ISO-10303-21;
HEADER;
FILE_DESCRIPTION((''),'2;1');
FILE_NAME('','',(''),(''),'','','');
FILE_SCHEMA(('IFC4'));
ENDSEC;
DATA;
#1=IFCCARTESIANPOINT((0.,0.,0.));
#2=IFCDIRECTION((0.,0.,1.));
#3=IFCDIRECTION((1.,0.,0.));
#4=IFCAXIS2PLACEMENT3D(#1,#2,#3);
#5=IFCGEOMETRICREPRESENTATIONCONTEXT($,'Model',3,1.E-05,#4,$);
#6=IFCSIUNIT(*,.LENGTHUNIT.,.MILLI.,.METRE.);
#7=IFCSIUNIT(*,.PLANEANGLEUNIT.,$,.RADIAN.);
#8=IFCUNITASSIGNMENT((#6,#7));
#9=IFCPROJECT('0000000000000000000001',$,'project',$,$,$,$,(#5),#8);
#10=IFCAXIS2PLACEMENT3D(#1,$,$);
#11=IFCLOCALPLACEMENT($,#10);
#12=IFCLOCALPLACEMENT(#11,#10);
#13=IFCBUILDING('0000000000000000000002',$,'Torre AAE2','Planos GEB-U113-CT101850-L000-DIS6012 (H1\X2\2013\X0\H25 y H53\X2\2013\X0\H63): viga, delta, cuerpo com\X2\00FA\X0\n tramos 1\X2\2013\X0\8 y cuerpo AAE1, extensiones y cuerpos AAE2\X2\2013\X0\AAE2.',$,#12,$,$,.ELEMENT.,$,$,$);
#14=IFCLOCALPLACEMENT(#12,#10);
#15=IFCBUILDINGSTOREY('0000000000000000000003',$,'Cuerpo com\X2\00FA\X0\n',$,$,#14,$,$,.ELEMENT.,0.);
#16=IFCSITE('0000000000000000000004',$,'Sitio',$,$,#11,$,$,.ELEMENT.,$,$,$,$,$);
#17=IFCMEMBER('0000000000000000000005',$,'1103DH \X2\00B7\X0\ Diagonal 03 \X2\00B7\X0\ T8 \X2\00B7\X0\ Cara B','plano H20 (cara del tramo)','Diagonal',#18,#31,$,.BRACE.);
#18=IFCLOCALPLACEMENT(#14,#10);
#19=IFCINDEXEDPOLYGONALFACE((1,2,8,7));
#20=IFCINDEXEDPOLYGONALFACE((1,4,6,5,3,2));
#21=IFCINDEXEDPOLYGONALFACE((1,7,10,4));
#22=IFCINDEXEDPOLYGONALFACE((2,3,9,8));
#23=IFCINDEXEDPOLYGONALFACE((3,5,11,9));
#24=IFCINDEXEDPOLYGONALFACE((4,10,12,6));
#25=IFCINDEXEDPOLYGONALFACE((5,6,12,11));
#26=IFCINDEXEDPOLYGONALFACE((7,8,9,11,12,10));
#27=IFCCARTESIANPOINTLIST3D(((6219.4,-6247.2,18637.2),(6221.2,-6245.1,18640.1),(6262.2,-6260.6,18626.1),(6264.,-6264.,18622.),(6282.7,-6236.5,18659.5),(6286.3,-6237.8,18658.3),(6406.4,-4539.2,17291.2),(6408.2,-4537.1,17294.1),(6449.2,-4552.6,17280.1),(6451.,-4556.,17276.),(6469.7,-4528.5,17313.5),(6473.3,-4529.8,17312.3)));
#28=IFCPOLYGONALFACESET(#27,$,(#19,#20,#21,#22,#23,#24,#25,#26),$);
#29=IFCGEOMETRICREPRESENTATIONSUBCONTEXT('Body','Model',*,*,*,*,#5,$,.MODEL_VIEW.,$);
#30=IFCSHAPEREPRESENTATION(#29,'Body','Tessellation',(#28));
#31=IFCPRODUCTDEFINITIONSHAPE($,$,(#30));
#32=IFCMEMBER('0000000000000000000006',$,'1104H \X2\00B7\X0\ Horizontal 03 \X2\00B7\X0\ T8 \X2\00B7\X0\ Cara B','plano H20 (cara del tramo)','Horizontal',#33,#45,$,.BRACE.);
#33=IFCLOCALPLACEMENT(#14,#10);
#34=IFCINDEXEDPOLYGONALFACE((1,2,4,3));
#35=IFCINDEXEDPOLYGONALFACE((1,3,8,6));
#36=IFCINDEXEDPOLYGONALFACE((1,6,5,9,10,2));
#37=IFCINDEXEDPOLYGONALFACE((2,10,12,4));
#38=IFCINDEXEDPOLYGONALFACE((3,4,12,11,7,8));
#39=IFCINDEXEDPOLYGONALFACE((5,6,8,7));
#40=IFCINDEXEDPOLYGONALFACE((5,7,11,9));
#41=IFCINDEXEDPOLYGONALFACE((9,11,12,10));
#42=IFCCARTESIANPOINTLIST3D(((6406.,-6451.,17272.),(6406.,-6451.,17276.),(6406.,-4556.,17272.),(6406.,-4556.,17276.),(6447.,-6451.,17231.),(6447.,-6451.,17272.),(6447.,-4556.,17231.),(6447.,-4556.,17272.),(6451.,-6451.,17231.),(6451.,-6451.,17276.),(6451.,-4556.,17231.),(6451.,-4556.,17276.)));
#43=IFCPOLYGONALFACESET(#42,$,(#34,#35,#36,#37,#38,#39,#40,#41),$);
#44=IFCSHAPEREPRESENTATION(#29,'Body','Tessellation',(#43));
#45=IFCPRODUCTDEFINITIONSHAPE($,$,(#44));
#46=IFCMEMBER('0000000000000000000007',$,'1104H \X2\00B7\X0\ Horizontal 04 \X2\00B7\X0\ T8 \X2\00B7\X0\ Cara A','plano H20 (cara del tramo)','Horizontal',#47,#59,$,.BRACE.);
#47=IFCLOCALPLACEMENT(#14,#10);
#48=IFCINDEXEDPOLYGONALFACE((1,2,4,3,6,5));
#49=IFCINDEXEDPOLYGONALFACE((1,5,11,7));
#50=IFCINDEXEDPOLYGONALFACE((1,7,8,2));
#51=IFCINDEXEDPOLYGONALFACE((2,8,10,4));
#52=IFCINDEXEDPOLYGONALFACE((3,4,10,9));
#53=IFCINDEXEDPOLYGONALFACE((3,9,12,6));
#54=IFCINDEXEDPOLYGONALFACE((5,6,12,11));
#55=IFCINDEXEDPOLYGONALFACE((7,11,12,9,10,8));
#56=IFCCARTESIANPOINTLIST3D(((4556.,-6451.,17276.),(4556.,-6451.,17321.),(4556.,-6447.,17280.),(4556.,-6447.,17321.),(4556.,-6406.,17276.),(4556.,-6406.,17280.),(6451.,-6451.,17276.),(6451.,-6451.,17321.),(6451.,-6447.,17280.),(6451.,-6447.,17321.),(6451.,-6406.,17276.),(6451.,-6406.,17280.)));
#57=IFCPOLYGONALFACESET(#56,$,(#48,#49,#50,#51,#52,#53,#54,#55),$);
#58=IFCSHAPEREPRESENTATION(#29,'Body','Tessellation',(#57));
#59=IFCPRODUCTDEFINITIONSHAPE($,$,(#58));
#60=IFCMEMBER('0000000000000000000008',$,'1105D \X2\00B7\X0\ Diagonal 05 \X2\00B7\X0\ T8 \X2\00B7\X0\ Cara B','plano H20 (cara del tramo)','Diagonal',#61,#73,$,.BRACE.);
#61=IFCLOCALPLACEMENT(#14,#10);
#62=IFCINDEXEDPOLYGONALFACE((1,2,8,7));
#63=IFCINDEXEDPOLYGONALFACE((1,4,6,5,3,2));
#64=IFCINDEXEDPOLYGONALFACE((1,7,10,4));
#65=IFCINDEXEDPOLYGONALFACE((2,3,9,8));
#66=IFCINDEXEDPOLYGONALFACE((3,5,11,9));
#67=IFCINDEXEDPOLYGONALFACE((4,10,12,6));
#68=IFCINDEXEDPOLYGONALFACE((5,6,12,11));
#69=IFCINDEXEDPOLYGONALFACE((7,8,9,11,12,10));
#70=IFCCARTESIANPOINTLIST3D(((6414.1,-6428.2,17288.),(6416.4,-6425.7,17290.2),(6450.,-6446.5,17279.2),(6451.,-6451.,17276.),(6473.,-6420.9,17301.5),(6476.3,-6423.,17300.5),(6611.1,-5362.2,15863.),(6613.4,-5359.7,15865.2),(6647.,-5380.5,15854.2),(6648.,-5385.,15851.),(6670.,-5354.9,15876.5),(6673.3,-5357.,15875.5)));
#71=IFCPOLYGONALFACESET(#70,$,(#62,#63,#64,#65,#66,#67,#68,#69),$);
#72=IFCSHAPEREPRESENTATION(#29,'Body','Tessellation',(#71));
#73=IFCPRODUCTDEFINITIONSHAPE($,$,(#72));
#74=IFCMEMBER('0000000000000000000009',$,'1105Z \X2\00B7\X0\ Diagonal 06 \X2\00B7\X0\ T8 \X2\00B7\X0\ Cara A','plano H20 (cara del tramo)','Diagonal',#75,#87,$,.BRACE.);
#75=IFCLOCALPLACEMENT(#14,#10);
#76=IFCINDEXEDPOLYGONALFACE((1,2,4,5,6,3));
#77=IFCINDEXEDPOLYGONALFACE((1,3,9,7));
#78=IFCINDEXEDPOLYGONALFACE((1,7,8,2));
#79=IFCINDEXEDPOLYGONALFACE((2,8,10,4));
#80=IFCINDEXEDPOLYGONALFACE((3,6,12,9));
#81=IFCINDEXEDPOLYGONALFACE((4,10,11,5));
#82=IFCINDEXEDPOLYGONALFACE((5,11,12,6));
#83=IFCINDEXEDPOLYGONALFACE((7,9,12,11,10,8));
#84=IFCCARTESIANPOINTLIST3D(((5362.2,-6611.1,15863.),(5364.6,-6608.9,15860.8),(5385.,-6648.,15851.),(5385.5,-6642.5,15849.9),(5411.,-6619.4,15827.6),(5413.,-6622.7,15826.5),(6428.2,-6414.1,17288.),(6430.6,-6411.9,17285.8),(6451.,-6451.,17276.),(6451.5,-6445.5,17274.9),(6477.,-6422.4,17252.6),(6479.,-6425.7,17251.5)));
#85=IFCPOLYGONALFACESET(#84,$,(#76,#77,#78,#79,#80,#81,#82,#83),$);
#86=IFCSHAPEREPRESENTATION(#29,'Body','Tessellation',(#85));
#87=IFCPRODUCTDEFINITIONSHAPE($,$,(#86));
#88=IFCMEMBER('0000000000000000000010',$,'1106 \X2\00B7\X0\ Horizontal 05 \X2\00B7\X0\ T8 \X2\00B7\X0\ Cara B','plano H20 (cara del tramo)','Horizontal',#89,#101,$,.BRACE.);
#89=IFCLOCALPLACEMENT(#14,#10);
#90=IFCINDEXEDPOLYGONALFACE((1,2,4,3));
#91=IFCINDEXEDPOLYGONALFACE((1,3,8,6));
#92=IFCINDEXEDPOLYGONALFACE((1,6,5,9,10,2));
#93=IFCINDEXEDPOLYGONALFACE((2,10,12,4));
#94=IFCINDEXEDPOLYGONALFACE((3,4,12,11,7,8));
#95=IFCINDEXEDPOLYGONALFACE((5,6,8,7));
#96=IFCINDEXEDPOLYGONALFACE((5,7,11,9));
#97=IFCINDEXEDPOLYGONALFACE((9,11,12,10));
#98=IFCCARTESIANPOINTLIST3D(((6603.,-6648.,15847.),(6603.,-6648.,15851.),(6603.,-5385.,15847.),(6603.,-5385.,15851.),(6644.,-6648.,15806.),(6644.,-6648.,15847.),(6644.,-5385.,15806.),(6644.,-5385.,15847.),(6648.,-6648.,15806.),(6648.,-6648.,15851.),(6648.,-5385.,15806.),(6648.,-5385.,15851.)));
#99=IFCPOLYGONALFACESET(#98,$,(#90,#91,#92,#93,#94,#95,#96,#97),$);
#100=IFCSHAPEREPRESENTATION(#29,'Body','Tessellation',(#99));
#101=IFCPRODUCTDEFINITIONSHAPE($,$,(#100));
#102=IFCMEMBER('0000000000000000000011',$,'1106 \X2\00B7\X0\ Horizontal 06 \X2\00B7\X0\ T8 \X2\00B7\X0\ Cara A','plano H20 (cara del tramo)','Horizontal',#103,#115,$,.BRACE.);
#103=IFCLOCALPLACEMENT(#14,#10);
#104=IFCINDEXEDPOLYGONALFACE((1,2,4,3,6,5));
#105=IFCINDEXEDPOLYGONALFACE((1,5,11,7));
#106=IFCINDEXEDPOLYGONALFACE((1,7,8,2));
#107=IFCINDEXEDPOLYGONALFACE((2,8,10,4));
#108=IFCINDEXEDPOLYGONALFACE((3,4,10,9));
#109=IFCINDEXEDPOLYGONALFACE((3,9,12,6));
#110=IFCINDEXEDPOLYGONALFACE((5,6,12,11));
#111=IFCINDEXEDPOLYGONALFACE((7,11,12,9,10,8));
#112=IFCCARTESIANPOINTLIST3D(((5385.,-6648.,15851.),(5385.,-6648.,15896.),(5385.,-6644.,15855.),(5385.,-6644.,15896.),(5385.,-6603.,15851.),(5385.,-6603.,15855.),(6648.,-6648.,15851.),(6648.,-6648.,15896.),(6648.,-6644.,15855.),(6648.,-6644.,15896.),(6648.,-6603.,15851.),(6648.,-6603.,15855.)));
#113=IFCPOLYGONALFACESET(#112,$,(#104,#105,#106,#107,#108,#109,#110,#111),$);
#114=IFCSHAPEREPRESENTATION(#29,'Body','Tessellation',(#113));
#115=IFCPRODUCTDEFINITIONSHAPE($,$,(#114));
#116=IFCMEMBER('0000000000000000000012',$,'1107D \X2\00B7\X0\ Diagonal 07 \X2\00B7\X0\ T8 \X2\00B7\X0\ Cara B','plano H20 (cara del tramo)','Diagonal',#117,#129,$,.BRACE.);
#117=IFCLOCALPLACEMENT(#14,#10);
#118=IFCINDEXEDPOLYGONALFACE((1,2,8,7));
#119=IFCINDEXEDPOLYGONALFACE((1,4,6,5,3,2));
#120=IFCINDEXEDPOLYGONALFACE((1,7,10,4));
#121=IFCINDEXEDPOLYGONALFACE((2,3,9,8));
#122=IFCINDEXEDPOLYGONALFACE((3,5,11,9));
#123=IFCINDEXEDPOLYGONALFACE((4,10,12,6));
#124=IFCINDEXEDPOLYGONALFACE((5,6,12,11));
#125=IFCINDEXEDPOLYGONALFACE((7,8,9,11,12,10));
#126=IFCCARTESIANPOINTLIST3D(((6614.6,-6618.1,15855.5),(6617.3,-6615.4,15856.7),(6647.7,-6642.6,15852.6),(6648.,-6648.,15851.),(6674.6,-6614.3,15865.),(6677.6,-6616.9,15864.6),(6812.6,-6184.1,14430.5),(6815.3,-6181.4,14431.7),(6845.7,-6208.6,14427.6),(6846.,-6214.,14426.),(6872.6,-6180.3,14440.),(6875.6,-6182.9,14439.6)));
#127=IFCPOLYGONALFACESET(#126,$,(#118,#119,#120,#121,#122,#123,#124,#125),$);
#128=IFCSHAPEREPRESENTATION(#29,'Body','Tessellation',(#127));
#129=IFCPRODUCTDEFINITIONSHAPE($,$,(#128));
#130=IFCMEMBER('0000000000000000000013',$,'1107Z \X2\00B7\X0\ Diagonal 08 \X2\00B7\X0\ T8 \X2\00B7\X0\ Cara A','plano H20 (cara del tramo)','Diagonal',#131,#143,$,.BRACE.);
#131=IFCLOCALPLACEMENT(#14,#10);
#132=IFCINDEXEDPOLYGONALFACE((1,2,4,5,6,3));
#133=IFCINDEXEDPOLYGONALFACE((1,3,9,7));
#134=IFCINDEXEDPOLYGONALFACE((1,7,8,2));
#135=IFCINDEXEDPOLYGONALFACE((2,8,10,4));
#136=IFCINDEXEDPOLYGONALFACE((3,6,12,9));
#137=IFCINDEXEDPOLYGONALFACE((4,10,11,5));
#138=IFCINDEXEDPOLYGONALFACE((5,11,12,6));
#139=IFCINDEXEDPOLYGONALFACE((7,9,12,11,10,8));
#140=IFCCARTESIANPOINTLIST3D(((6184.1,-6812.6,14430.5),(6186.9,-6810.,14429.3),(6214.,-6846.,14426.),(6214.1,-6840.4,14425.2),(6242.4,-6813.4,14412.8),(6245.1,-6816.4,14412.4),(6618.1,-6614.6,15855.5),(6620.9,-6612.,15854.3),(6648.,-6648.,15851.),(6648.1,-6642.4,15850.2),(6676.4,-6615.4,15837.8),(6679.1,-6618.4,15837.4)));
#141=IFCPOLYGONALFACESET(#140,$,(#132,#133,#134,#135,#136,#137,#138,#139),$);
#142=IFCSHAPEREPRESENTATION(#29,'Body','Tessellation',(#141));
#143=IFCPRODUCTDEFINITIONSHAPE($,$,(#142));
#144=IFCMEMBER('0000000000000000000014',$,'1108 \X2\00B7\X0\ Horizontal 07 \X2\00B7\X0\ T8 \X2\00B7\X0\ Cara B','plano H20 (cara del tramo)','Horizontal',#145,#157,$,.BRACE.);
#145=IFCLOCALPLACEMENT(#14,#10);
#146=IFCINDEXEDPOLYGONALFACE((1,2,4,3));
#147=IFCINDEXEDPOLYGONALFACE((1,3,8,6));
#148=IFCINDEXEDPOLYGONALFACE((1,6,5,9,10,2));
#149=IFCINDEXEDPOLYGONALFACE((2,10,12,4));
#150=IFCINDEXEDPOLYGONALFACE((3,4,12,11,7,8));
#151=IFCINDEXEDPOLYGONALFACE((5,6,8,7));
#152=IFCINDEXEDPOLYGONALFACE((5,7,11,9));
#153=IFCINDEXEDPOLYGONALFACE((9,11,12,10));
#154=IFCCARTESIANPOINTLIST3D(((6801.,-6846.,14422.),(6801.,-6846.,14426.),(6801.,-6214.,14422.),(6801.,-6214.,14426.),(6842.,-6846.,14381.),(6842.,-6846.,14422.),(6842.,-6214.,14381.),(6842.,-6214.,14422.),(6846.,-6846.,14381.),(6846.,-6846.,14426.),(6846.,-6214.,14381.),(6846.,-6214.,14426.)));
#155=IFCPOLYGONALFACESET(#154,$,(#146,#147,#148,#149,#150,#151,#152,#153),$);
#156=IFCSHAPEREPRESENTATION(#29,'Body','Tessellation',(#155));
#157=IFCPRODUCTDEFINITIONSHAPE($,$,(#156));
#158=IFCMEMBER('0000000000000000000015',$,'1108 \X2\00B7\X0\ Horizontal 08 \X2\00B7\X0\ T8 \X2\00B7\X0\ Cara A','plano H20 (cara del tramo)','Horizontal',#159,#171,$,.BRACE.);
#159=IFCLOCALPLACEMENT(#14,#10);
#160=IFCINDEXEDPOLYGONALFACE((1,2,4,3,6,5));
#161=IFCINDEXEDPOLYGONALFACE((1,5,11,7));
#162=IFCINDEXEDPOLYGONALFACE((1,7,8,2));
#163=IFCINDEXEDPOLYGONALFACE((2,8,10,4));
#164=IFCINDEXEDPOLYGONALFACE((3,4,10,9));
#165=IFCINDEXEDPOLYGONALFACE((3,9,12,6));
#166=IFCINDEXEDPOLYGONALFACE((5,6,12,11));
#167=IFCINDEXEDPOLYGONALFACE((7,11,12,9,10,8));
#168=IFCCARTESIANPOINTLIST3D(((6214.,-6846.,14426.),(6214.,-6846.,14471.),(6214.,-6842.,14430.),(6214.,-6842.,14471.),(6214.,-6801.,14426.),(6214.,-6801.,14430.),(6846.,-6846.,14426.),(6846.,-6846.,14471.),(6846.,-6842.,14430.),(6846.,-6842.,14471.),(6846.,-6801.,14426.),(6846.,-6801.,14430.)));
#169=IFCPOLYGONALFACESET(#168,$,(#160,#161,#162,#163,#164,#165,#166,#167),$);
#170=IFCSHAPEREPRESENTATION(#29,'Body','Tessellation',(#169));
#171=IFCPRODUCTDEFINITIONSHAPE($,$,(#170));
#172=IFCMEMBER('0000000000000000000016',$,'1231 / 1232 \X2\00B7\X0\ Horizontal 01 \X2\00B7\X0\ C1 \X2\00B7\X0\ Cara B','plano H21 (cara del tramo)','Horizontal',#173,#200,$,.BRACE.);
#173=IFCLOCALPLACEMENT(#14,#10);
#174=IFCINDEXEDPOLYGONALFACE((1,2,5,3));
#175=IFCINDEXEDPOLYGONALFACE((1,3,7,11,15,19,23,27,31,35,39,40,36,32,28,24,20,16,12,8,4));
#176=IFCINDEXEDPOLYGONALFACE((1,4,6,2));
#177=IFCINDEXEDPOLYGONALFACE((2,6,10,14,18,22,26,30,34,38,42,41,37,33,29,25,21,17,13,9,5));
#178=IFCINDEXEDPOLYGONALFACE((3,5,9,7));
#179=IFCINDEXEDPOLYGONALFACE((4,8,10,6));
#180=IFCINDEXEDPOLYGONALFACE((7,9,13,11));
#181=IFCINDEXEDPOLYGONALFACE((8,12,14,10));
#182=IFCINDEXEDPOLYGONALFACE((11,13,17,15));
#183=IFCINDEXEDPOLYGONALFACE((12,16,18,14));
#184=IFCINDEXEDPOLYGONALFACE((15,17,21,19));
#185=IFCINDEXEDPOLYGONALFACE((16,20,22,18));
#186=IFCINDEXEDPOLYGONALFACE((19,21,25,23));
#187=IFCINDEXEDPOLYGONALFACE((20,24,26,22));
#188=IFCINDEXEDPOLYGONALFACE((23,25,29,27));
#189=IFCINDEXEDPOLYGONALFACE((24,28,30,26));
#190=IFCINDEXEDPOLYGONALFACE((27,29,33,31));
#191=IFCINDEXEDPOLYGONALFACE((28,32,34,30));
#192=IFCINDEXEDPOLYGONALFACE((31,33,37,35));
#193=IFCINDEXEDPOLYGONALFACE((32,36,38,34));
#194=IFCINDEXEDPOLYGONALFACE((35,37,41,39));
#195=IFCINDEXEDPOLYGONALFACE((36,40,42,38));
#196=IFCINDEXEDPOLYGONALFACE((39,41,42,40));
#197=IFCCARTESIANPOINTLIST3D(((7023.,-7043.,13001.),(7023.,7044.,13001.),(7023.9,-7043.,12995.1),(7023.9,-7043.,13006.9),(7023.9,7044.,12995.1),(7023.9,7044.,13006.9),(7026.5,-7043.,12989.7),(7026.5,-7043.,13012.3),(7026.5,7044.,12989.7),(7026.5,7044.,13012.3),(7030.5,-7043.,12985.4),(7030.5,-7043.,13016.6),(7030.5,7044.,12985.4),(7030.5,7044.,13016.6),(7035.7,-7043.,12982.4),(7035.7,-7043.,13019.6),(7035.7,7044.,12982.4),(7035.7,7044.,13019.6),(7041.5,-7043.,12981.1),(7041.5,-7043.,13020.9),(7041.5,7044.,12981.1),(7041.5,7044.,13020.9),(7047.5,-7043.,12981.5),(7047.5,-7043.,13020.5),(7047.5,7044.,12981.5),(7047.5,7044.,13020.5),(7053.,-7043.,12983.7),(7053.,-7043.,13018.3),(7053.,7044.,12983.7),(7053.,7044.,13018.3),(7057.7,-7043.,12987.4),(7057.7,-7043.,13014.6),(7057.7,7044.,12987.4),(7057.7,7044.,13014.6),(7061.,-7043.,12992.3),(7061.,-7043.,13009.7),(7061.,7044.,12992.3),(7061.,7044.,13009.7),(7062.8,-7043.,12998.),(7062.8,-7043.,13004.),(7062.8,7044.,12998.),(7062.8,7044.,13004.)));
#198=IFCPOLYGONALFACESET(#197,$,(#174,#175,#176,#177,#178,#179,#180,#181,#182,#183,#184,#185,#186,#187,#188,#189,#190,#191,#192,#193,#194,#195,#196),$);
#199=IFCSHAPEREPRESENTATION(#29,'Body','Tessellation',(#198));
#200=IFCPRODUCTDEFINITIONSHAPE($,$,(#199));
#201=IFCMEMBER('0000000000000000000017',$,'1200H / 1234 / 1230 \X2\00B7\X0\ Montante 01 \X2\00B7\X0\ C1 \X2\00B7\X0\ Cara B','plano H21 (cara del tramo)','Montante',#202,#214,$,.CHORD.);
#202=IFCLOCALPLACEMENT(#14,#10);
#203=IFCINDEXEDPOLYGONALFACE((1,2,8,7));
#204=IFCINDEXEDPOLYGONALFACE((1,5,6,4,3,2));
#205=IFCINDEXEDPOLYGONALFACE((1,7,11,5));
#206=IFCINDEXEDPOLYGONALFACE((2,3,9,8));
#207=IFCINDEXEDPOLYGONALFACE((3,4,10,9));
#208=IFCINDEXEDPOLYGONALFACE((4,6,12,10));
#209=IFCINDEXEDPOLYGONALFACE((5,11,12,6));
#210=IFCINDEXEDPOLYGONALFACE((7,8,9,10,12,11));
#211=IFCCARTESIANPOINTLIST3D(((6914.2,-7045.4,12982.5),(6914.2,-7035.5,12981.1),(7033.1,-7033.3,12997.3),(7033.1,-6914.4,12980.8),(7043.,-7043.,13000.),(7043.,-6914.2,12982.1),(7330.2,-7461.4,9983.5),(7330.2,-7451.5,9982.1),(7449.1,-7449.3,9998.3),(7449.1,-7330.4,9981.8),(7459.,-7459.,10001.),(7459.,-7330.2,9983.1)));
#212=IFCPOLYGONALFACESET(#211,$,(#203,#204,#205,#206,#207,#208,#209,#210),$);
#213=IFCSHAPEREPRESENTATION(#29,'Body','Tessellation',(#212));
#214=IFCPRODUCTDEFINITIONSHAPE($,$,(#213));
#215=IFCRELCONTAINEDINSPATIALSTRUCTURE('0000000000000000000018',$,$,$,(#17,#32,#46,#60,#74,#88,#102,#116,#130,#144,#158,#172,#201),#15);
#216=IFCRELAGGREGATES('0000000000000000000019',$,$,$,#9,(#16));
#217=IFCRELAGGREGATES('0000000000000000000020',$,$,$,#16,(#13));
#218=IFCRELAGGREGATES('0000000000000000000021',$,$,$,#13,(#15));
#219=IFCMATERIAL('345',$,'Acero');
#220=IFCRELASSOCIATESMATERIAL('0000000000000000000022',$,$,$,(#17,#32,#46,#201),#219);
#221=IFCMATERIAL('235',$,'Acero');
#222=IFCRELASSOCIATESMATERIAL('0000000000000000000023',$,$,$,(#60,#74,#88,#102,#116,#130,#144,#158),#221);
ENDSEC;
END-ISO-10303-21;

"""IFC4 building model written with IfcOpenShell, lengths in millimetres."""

from ifc_helpers import new_model, si_unit, frame, frame_2d, origin, origin_with_axes, place, context, subcontext, project, spatial, circle, l_section, extrude, material, element, save


model = new_model("IFC4")

# Units and contexts
model_context = context("Model", 3, precision=1e-05, world=origin_with_axes())
body_context = subcontext(model_context, "Body", "Model", "MODEL_VIEW")
ifc_project = project(units=[si_unit("LENGTHUNIT", "METRE", prefix="MILLI"), si_unit("PLANEANGLEUNIT", "RADIAN")], contexts=[model_context])

# Site, building, storey
site_placement = place(None, origin())
site = spatial("IfcSite", under=ifc_project, at=site_placement, Name="Sitio", CompositionType="ELEMENT")
building_placement = place(site_placement, origin())
building = spatial("IfcBuilding", under=site, at=building_placement, Name="Torre AAE2", Description="Planos GEB-U113-CT101850-L000-DIS6012 (H1–H25 y H53–H63): viga, delta, cuerpo común tramos 1–8 y cuerpo AAE1, extensiones y cuerpos AAE2–AAE2.", CompositionType="ELEMENT")
storey_placement = place(building_placement, origin())
storey = spatial("IfcBuildingStorey", under=building, at=storey_placement, Name="Cuerpo común", CompositionType="ELEMENT", Elevation=0.0)

# Members
ifc_material_1 = material(Name="345", Category="Acero")
member_1_placement = place(storey_placement, frame((6264.0, -6264.0, 18622.0), z_axis=(0.085676, 0.782536, -0.616682), x_axis=(-0.891166, 0.336961, 0.303776)))
element("IfcMember", 1, at=member_1_placement, inside=storey, material=ifc_material_1, Name="1103DH · Diagonal 03 · T8 · Cara B", Description="plano H20 (cara del tramo)", ObjectType="Diagonal", PredefinedType="BRACE", context=body_context, shape_type="SweptSolid", body=[
    extrude(l_section(Depth=50.0, Width=50.0, Thickness=4.0, at=frame_2d((25.0, 25.0))), None, (0.0, 0.0, 1.0), 2182.6),
])
for number, where, z_axis, x_axis, name in (
    (2, (6451.0, -4556.0, 17276.0), (0.0, -1.0, 0.0), (-1.0, 0.0, 0.0), "1104H · Horizontal 03 · T8 · Cara B"),
    (3, (4556.0, -6451.0, 17276.0), (1.0, 0.0, 0.0), (0.0, 1.0, 0.0), "1104H · Horizontal 04 · T8 · Cara A"),
):
    element("IfcMember", number, at=place(storey_placement, frame(where, z_axis=z_axis, x_axis=x_axis)), inside=storey, material=ifc_material_1, Name=name, Description="plano H20 (cara del tramo)", ObjectType="Horizontal", PredefinedType="BRACE", context=body_context, shape_type="SweptSolid", body=[
        extrude(l_section(Depth=45.0, Width=45.0, Thickness=4.0, at=frame_2d((22.5, 22.5))), None, (0.0, 0.0, 1.0), 1895.0),
    ])
ifc_material_2 = material(Name="235", Category="Acero")
for number, where, z_axis, x_axis, name in (
    (4, (6451.0, -6451.0, 17276.0), (0.110027, 0.595374, -0.79588), (-0.819305, 0.507658, 0.266499), "1105D · Diagonal 05 · T8 · Cara B"),
    (5, (6451.0, -6451.0, 17276.0), (-0.595374, -0.110027, -0.79588), (-0.507658, 0.819305, 0.266499), "1105Z · Diagonal 06 · T8 · Cara A"),
):
    element("IfcMember", number, at=place(storey_placement, frame(where, z_axis=z_axis, x_axis=x_axis)), inside=storey, material=ifc_material_2, Name=name, Description="plano H20 (cara del tramo)", ObjectType="Diagonal", PredefinedType="BRACE", context=body_context, shape_type="SweptSolid", body=[
        extrude(l_section(Depth=45.0, Width=45.0, Thickness=4.0, at=frame_2d((22.5, 22.5))), None, (0.0, 0.0, 1.0), 1790.5),
    ])
for number, where, z_axis, x_axis, name in (
    (6, (6648.0, -5385.0, 15851.0), (0.0, -1.0, 0.0), (-1.0, 0.0, 0.0), "1106 · Horizontal 05 · T8 · Cara B"),
    (7, (5385.0, -6648.0, 15851.0), (1.0, 0.0, 0.0), (0.0, 1.0, 0.0), "1106 · Horizontal 06 · T8 · Cara A"),
):
    element("IfcMember", number, at=place(storey_placement, frame(where, z_axis=z_axis, x_axis=x_axis)), inside=storey, material=ifc_material_2, Name=name, Description="plano H20 (cara del tramo)", ObjectType="Horizontal", PredefinedType="BRACE", context=body_context, shape_type="SweptSolid", body=[
        extrude(l_section(Depth=45.0, Width=45.0, Thickness=4.0, at=frame_2d((22.5, 22.5))), None, (0.0, 0.0, 1.0), 1263.0),
    ])
for number, where, z_axis, x_axis, name in (
    (8, (6648.0, -6648.0, 15851.0), (0.131761, 0.288808, -0.948277), (-0.741556, 0.663539, 0.099051), "1107D · Diagonal 07 · T8 · Cara B"),
    (9, (6648.0, -6648.0, 15851.0), (-0.288808, -0.131761, -0.948277), (-0.663539, 0.741556, 0.099051), "1107Z · Diagonal 08 · T8 · Cara A"),
):
    element("IfcMember", number, at=place(storey_placement, frame(where, z_axis=z_axis, x_axis=x_axis)), inside=storey, material=ifc_material_2, Name=name, Description="plano H20 (cara del tramo)", ObjectType="Diagonal", PredefinedType="BRACE", context=body_context, shape_type="SweptSolid", body=[
        extrude(l_section(Depth=45.0, Width=45.0, Thickness=4.0, at=frame_2d((22.5, 22.5))), None, (0.0, 0.0, 1.0), 1502.7),
    ])
for number, where, z_axis, x_axis, name in (
    (10, (6846.0, -6214.0, 14426.0), (0.0, -1.0, 0.0), (-1.0, 0.0, 0.0), "1108 · Horizontal 07 · T8 · Cara B"),
    (11, (6214.0, -6846.0, 14426.0), (1.0, 0.0, 0.0), (0.0, 1.0, 0.0), "1108 · Horizontal 08 · T8 · Cara A"),
):
    element("IfcMember", number, at=place(storey_placement, frame(where, z_axis=z_axis, x_axis=x_axis)), inside=storey, material=ifc_material_2, Name=name, Description="plano H20 (cara del tramo)", ObjectType="Horizontal", PredefinedType="BRACE", context=body_context, shape_type="SweptSolid", body=[
        extrude(l_section(Depth=45.0, Width=45.0, Thickness=4.0, at=frame_2d((22.5, 22.5))), None, (0.0, 0.0, 1.0), 632.0),
    ])
member_2_placement = place(storey_placement, frame((7043.0, -7043.0, 13001.0), z_axis=(0.0, 1.0, 0.0), x_axis=(-1.0, 0.0, 0.0)))
element("IfcMember", 12, at=member_2_placement, inside=storey, Name="1231 / 1232 · Horizontal 01 · C1 · Cara B", Description="plano H21 (cara del tramo)", ObjectType="Horizontal", PredefinedType="BRACE", context=body_context, shape_type="SweptSolid", body=[
    extrude(circle(Radius=20.0), None, (0.0, 0.0, 1.0), 14087.0),
])
member_3_placement = place(storey_placement, frame((7043.0, -7043.0, 13000.0), z_axis=(0.136119, -0.136119, -0.981297), x_axis=(-0.990693, -0.018702, -0.134828)))
element("IfcMember", 13, at=member_3_placement, inside=storey, material=ifc_material_1, Name="1200H / 1234 / 1230 · Montante 01 · C1 · Cara B", Description="plano H21 (cara del tramo)", ObjectType="Montante", PredefinedType="CHORD", context=body_context, shape_type="SweptSolid", body=[
    extrude(l_section(Depth=130.0, Width=130.0, Thickness=10.0, at=frame_2d((65.0, 65.0))), None, (0.0, 0.0, 1.0), 3056.2),
])

save(model, "model.ifc")
